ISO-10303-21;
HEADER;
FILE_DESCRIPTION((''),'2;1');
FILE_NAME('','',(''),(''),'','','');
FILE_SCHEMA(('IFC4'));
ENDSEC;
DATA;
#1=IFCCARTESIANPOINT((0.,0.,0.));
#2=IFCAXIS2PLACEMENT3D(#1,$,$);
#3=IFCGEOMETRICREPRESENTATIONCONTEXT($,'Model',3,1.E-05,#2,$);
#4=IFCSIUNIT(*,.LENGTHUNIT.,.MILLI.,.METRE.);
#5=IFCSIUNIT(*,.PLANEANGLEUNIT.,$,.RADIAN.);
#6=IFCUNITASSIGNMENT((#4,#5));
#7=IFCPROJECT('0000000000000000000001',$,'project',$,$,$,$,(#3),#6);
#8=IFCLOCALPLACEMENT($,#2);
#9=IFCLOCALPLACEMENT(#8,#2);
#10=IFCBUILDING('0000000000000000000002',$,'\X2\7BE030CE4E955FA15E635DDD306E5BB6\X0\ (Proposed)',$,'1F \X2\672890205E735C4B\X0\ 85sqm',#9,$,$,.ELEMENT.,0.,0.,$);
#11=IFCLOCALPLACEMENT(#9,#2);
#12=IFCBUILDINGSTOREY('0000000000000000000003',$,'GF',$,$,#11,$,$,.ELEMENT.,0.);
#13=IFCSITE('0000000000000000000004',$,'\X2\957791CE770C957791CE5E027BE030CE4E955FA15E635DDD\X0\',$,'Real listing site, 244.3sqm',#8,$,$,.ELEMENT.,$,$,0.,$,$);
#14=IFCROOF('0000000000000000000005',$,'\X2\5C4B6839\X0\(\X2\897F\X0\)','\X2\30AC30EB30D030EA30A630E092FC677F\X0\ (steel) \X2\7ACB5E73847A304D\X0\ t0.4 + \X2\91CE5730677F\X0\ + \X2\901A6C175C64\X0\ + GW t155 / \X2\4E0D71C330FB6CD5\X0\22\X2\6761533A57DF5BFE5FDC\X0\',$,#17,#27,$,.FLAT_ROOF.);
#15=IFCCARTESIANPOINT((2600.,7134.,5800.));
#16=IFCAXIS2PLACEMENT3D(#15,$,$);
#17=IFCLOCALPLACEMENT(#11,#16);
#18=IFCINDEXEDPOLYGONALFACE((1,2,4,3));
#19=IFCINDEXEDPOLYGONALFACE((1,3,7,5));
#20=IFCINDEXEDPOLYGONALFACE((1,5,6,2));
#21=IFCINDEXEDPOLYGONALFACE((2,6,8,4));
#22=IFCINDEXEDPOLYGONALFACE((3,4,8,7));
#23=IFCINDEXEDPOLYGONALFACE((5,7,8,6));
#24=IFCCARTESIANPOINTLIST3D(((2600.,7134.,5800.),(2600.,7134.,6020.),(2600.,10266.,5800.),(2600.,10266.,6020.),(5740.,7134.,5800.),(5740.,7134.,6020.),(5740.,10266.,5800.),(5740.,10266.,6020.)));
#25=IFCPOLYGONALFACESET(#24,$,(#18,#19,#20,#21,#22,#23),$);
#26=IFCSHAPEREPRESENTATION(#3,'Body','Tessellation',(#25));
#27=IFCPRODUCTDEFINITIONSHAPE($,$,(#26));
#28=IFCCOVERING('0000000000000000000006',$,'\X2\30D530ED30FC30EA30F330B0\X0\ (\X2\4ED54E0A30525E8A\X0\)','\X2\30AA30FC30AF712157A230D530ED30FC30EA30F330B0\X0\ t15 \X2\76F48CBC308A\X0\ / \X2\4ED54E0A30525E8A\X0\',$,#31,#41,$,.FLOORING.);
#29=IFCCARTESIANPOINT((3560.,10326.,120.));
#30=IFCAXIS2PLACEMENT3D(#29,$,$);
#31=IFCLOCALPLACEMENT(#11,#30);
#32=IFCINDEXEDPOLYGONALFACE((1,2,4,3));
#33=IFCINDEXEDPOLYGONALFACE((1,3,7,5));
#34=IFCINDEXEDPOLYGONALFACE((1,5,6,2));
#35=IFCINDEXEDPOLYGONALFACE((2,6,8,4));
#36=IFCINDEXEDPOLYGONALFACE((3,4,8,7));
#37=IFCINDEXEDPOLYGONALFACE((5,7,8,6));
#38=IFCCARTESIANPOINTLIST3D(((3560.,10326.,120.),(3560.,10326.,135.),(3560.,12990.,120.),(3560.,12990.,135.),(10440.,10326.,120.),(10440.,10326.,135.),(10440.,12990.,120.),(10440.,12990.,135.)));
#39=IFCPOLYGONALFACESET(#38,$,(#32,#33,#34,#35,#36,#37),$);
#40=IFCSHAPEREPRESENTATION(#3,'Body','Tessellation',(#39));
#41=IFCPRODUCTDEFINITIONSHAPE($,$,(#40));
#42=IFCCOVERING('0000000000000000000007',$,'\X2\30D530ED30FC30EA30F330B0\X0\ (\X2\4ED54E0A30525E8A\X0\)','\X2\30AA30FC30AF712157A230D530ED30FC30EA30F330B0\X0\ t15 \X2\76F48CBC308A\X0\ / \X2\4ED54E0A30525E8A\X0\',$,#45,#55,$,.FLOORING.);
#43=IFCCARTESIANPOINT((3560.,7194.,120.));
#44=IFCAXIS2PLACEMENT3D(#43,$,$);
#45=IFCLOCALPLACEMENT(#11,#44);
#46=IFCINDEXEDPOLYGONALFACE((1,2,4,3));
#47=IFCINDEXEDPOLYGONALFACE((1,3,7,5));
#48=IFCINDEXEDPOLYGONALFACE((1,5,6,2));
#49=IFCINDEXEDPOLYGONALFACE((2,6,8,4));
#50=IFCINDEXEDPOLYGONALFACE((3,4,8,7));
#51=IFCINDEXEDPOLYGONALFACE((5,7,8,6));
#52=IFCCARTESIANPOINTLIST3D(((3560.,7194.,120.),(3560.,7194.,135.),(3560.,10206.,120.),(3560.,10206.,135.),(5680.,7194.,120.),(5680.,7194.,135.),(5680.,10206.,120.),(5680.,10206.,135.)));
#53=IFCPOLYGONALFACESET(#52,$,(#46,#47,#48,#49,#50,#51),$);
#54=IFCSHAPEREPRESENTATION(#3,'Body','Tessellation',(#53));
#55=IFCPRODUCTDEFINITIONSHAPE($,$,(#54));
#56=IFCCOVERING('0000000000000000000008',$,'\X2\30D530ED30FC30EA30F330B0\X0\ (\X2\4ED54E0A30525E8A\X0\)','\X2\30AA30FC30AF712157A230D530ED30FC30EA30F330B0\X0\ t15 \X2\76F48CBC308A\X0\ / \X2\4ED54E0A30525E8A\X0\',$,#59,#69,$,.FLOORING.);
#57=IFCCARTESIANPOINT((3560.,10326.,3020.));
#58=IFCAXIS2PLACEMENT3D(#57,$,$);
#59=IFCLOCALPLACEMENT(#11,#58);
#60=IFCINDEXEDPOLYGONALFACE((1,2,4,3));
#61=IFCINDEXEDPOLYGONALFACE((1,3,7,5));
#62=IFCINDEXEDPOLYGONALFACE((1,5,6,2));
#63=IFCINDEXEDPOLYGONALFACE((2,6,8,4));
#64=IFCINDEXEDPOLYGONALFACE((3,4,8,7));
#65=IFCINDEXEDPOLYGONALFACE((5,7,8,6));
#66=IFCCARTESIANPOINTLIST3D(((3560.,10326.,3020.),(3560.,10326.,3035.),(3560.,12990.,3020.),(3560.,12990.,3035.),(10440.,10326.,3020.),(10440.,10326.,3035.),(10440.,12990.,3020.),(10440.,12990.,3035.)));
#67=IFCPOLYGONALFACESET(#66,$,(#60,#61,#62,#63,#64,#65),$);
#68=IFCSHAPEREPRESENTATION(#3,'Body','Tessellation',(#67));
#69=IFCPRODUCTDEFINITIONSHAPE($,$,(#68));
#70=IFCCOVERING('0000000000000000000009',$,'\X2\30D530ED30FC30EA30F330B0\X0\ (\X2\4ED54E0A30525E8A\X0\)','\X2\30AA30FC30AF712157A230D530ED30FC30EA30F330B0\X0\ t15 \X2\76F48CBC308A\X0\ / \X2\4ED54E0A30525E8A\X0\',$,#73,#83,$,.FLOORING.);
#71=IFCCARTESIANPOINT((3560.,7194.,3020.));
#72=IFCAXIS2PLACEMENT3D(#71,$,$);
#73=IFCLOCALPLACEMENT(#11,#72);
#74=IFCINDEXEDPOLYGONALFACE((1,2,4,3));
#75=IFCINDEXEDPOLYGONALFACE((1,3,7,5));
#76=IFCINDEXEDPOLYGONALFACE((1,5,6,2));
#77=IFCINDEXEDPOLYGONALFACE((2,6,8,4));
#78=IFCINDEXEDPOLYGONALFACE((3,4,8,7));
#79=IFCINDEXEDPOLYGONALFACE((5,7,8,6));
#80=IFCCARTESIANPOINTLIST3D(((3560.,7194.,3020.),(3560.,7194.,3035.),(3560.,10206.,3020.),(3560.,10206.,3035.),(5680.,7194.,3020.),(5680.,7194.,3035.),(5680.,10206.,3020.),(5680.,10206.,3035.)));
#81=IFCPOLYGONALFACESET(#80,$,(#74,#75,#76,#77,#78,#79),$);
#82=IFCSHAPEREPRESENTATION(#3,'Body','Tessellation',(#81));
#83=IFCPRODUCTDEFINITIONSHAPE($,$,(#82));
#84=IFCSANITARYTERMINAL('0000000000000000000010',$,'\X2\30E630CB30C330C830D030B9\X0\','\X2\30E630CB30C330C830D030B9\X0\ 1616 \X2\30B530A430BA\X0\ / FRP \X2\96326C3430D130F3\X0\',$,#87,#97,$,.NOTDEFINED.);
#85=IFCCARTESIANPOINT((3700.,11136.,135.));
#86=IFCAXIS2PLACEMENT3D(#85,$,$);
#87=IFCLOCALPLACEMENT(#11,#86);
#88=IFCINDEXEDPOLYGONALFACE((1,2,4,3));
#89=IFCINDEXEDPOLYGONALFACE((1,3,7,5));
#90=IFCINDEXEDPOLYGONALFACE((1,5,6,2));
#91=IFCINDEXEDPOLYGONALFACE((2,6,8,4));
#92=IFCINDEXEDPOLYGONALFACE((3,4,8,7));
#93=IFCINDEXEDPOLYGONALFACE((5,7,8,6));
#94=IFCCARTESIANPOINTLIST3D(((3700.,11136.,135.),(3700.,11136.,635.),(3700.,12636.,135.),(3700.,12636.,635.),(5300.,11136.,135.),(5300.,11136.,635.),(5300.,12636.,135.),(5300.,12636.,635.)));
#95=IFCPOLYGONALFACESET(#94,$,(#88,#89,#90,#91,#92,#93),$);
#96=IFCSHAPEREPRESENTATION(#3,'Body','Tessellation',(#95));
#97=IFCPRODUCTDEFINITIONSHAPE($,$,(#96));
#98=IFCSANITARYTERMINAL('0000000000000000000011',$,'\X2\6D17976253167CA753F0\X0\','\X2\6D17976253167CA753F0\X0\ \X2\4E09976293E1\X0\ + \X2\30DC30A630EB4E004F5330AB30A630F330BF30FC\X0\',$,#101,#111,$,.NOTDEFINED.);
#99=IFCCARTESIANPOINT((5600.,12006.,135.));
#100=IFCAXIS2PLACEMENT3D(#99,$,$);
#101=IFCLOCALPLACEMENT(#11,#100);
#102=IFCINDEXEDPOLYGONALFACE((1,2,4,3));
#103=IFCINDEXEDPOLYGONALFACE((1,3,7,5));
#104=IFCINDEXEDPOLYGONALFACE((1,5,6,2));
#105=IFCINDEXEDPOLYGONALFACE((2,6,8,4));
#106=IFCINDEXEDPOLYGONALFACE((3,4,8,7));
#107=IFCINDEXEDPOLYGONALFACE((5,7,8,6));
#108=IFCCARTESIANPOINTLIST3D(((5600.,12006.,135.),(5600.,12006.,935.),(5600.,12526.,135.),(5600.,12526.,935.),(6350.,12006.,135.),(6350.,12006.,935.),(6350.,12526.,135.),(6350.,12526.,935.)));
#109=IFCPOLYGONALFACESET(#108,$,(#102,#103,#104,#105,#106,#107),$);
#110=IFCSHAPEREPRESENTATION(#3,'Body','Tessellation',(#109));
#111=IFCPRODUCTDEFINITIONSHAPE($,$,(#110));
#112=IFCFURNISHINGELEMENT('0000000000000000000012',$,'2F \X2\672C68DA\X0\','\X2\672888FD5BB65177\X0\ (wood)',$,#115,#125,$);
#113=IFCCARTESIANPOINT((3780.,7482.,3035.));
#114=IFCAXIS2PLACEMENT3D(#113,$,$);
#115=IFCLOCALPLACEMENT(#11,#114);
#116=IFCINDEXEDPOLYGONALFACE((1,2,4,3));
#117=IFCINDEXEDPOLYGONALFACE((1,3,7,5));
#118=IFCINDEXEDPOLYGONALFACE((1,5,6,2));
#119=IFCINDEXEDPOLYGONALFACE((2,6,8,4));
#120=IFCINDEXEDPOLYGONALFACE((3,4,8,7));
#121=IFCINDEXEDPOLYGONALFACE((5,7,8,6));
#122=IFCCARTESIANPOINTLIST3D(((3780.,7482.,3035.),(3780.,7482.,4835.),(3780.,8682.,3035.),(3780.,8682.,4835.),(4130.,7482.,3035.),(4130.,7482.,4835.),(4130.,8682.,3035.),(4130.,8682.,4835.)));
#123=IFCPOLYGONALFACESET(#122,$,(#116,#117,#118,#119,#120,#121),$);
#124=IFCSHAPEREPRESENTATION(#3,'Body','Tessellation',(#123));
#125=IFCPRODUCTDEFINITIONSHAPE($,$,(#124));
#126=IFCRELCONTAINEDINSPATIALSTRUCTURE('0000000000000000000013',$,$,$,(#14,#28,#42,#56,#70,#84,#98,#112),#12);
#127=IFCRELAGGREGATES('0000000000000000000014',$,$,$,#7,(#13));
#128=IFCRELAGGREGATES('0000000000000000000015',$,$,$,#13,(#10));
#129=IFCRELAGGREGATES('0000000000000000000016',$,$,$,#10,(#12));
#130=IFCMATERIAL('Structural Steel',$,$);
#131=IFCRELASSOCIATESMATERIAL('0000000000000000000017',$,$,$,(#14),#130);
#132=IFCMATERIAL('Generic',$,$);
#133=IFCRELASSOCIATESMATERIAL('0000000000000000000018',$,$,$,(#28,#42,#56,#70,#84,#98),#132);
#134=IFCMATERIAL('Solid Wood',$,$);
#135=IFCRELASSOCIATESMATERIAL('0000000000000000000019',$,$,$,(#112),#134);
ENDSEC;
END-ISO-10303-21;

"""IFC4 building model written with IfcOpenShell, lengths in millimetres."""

from ifc_helpers import new_model, si_unit, frame, frame_2d, origin, place, context, project, spatial, rectangle, extrude, material, element, save


model = new_model("IFC4")

# Units and contexts
model_context = context("Model", 3, precision=1e-05, world=origin())
ifc_project = project(units=[si_unit("LENGTHUNIT", "METRE", prefix="MILLI"), si_unit("PLANEANGLEUNIT", "RADIAN")], contexts=[model_context])

# Site, building, storey
site_placement = place(None, origin())
site = spatial("IfcSite", under=ifc_project, at=site_placement, Name="長野県長野市篠ノ井御幣川", ObjectType="Real listing site, 244.3sqm", CompositionType="ELEMENT", RefElevation=0.0)
building_placement = place(site_placement, origin())
building = spatial("IfcBuilding", under=site, at=building_placement, Name="篠ノ井御幣川の家 (Proposed)", ObjectType="1F 木造平屋 85sqm", CompositionType="ELEMENT", ElevationOfRefHeight=0.0, ElevationOfTerrain=0.0)
storey_placement = place(building_placement, origin())
storey = spatial("IfcBuildingStorey", under=building, at=storey_placement, Name="GF", CompositionType="ELEMENT", Elevation=0.0)

# Shared definitions
ifc_material_1 = material(Name="Solid Wood")

# Roof
ifc_material_2 = material(Name="Structural Steel")
roof_placement = place(storey_placement, frame((2600.0, 7134.0, 5800.0)))
element("IfcRoof", 1, at=roof_placement, inside=storey, material=ifc_material_2, Name="屋根(西)", Description="ガルバリウム鋼板 (steel) 立平葺き t0.4 + 野地板 + 通気層 + GW t155 / 不燃・法22条区域対応", PredefinedType="FLAT_ROOF", context=model_context, shape_type="SweptSolid", body=[
    extrude(rectangle(XDim=3140.0, YDim=3132.0, at=frame_2d((1570.0, 1566.0))), frame((2600.0, 7134.0, 5800.0)), (0.0, 0.0, 1.0), 220.0),
])

# Coverings
ifc_material_3 = material(Name="Generic")
covering_1_placement = place(storey_placement, frame((3560.0, 10326.0, 120.0)))
element("IfcCovering", 2, at=covering_1_placement, inside=storey, material=ifc_material_3, Name="フローリング (仕上げ床)", Description="オーク無垢フローリング t15 直貼り / 仕上げ床", PredefinedType="FLOORING", context=model_context, shape_type="SweptSolid", body=[
    extrude(rectangle(XDim=6880.0, YDim=2664.0, at=frame_2d((3440.0, 1332.0))), frame((3560.0, 10326.0, 120.0)), (0.0, 0.0, 1.0), 15.0),
])
covering_2_placement = place(storey_placement, frame((3560.0, 7194.0, 120.0)))
element("IfcCovering", 3, at=covering_2_placement, inside=storey, material=ifc_material_3, Name="フローリング (仕上げ床)", Description="オーク無垢フローリング t15 直貼り / 仕上げ床", PredefinedType="FLOORING", context=model_context, shape_type="SweptSolid", body=[
    extrude(rectangle(XDim=2120.0, YDim=3012.0, at=frame_2d((1060.0, 1506.0))), frame((3560.0, 7194.0, 120.0)), (0.0, 0.0, 1.0), 15.0),
])
covering_3_placement = place(storey_placement, frame((3560.0, 10326.0, 3020.0)))
element("IfcCovering", 4, at=covering_3_placement, inside=storey, material=ifc_material_3, Name="フローリング (仕上げ床)", Description="オーク無垢フローリング t15 直貼り / 仕上げ床", PredefinedType="FLOORING", context=model_context, shape_type="SweptSolid", body=[
    extrude(rectangle(XDim=6880.0, YDim=2664.0, at=frame_2d((3440.0, 1332.0))), frame((3560.0, 10326.0, 3020.0)), (0.0, 0.0, 1.0), 15.0),
])
covering_4_placement = place(storey_placement, frame((3560.0, 7194.0, 3020.0)))
element("IfcCovering", 5, at=covering_4_placement, inside=storey, material=ifc_material_3, Name="フローリング (仕上げ床)", Description="オーク無垢フローリング t15 直貼り / 仕上げ床", PredefinedType="FLOORING", context=model_context, shape_type="SweptSolid", body=[
    extrude(rectangle(XDim=2120.0, YDim=3012.0, at=frame_2d((1060.0, 1506.0))), frame((3560.0, 7194.0, 3020.0)), (0.0, 0.0, 1.0), 15.0),
])

# Sanitary terminals
sanitary_terminal_1_placement = place(storey_placement, frame((3700.0, 11136.0, 135.0)))
element("IfcSanitaryTerminal", 6, at=sanitary_terminal_1_placement, inside=storey, material=ifc_material_3, Name="ユニットバス", Description="ユニットバス 1616 サイズ / FRP 防水パン", PredefinedType="NOTDEFINED", context=model_context, shape_type="SweptSolid", body=[
    extrude(rectangle(XDim=1600.0, YDim=1500.0, at=frame_2d((800.0, 750.0))), frame((3700.0, 11136.0, 135.0)), (0.0, 0.0, 1.0), 500.0),
])
sanitary_terminal_2_placement = place(storey_placement, frame((5600.0, 12006.0, 135.0)))
element("IfcSanitaryTerminal", 7, at=sanitary_terminal_2_placement, inside=storey, material=ifc_material_3, Name="洗面化粧台", Description="洗面化粧台 三面鏡 + ボウル一体カウンター", PredefinedType="NOTDEFINED", context=model_context, shape_type="SweptSolid", body=[
    extrude(rectangle(XDim=750.0, YDim=520.0, at=frame_2d((375.0, 260.0))), frame((5600.0, 12006.0, 135.0)), (0.0, 0.0, 1.0), 800.0),
])

# Furnishing element
furnishing_placement = place(storey_placement, frame((3780.0, 7482.0, 3035.0)))
element("IfcFurnishingElement", 8, at=furnishing_placement, inside=storey, material=ifc_material_1, Name="2F 本棚", Description="木製家具 (wood)", context=model_context, shape_type="SweptSolid", body=[
    extrude(rectangle(XDim=350.0, YDim=1200.0, at=frame_2d((175.0, 600.0))), frame((3780.0, 7482.0, 3035.0)), (0.0, 0.0, 1.0), 1800.0),
])

save(model, "model.ifc")
